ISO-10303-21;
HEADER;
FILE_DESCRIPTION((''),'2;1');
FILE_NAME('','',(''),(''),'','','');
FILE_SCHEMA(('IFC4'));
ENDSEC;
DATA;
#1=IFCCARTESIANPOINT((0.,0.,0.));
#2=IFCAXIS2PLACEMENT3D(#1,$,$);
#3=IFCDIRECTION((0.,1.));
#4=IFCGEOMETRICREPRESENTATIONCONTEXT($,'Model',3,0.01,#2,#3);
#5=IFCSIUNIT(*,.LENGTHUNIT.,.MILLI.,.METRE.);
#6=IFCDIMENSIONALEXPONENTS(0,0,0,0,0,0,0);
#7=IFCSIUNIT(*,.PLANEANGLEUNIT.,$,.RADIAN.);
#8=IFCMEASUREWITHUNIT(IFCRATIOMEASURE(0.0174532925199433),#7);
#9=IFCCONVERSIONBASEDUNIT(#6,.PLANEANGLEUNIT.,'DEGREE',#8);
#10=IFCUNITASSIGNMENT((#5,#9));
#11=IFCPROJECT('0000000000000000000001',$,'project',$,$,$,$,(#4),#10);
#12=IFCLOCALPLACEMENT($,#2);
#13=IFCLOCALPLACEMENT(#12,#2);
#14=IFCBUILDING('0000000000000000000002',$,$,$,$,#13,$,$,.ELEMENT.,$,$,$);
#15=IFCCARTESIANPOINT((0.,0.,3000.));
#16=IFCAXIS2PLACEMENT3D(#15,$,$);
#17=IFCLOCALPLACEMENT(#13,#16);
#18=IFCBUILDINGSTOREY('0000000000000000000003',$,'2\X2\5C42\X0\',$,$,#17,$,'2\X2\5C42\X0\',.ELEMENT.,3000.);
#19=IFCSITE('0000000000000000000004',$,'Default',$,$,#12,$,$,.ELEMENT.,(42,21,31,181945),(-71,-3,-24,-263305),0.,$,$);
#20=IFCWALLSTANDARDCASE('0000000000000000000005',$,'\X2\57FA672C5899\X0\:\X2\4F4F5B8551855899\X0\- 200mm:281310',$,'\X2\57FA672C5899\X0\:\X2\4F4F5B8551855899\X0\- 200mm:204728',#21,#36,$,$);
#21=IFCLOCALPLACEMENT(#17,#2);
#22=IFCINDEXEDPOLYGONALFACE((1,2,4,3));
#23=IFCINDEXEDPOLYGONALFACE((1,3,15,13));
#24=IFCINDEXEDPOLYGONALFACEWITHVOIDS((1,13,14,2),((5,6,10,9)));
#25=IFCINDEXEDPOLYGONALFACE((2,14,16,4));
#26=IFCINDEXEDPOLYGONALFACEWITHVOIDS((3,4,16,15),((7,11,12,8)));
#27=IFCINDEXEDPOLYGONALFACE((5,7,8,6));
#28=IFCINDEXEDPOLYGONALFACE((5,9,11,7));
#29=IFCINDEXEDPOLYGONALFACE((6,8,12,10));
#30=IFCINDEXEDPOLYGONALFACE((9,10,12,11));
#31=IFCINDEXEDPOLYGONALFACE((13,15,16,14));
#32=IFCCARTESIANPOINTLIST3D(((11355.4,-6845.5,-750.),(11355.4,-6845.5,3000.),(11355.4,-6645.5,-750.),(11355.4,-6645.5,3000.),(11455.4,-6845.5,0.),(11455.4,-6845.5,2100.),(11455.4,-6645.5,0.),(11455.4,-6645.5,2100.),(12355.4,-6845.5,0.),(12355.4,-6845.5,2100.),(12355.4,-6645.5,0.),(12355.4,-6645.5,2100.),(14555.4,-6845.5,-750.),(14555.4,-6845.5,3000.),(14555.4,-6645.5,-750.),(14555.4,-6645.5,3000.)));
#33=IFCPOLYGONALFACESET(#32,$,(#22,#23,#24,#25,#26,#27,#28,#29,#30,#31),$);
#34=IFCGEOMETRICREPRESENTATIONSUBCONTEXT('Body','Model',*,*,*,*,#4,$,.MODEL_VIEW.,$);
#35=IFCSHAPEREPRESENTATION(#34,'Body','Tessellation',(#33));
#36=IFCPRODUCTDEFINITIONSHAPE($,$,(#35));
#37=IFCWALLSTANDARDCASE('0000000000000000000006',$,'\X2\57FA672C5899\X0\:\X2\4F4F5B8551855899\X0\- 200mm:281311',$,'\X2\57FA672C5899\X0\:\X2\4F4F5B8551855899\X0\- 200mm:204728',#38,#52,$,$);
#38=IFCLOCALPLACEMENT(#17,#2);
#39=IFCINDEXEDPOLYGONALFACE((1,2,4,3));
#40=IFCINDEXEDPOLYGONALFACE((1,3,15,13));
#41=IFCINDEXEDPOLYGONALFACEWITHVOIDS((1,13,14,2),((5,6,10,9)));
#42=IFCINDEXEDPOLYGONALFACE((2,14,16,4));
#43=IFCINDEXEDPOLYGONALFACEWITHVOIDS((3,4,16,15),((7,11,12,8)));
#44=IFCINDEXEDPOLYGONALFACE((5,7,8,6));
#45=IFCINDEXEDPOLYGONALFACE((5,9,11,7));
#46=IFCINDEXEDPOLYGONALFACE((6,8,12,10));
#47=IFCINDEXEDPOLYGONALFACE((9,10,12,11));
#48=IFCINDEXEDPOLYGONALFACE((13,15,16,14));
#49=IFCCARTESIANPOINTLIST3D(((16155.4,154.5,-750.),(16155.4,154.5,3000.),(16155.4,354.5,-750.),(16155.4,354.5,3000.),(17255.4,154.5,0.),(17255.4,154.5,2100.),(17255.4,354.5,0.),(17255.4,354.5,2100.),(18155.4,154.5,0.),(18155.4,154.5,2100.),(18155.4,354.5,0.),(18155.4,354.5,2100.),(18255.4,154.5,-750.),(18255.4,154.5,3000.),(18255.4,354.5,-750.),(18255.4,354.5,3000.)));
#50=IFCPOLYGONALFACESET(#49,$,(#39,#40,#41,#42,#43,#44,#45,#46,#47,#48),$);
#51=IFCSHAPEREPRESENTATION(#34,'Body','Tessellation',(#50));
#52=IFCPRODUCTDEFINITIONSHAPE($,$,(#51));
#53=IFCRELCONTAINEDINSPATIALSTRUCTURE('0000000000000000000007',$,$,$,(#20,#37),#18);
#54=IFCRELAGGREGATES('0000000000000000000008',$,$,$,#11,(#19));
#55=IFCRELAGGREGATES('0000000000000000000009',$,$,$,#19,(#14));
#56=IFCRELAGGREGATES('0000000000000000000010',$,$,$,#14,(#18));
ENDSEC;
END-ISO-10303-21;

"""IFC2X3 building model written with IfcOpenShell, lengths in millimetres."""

from ifc_helpers import new_model, entity, si_unit, converted_unit, direction, frame, frame_2d, origin, place, context, subcontext, project, spatial, polyline, rectangle, extrude, clip, bounded_halfspace, element, save


model = new_model("IFC2X3")

# Units and contexts
model_context = context("Model", 3, precision=0.01, world=origin(), true_north=direction((0.0, 1.0)))
body_context = subcontext(model_context, "Body", "Model", "MODEL_VIEW")
ifc_project = project(units=[si_unit("LENGTHUNIT", "METRE", prefix="MILLI"), converted_unit("PLANEANGLEUNIT", "DEGREE", entity("IfcRatioMeasure", 0.0174532925199433), si_unit("PLANEANGLEUNIT", "RADIAN"), dimensions=[0, 0, 0, 0, 0, 0, 0])], contexts=[model_context])

# Site, building, storey
site_placement = place(None, origin())
site = spatial("IfcSite", under=ifc_project, at=site_placement, Name="Default", CompositionType="ELEMENT", RefLatitude=(42, 21, 31, 181945), RefLongitude=(-71, -3, -24, -263305), RefElevation=0.0)
building_placement = place(site_placement, origin())
building = spatial("IfcBuilding", under=site, at=building_placement, CompositionType="ELEMENT")
storey_placement = place(building_placement, frame((0.0, 0.0, 3000.0)))
storey = spatial("IfcBuildingStorey", under=building, at=storey_placement, Name="2层", LongName="2层", CompositionType="ELEMENT", Elevation=3000.0)

# Wall, openings
wall_1_placement = place(storey_placement, frame((11355.4, -6745.5, -750.0)))
wall_1 = element("IfcWallStandardCase", 1, at=wall_1_placement, inside=storey, Name="基本墙:住宅内墙- 200mm:281310", ObjectType="基本墙:住宅内墙- 200mm:204728", context=body_context, shape_type="Clipping", body=[
    clip(clip(extrude(rectangle(XDim=3200.0, YDim=200.0, at=frame_2d((1600.0, 0.0), x_axis=(-1.0, 0.0))), origin(), (0.0, 0.0, 1.0), 3750.0), bounded_halfspace(frame((0.0, -100.0, 0.0), z_axis=(1.0, 0.0, 0.0), x_axis=(0.0, 0.0, -1.0)), True, frame((0.0, -100.0, 0.0), z_axis=(1.0, 0.0, 0.0), x_axis=(0.0, 0.0, -1.0)), polyline([(0.0, 0.0), (0.0, 200.0), (-3750.0, 200.0), (-3750.0, 0.0), (0.0, 0.0)]))), bounded_halfspace(frame((3200.0, -100.0, 3750.0), z_axis=(1.0, 0.0, 0.0), x_axis=(0.0, 0.0, -1.0)), False, frame((3200.0, -100.0, 3750.0), z_axis=(1.0, 0.0, 0.0), x_axis=(0.0, 0.0, -1.0)), polyline([(0.0, 0.0), (3750.0, 0.0), (3750.0, 200.0), (0.0, 200.0), (0.0, 0.0)]))),
])
opening_1_placement = place(wall_1_placement, origin())
element("IfcOpeningElement", 2, at=opening_1_placement, cuts=wall_1, ObjectType="Opening", context=body_context, shape_type="SweptSolid", body=[
    extrude(rectangle(XDim=2100.0, YDim=900.0, at=frame_2d((0.0, 0.0), x_axis=(1.0, 0.0))), frame((550.0, -1424.0, 4800.0), z_axis=(0.0, 1.0, 0.0), x_axis=(0.0, 0.0, 1.0)), (0.0, 0.0, 1.0), 3048.0),
])
opening_2_placement = place(wall_1_placement, origin())
element("IfcOpeningElement", 3, at=opening_2_placement, cuts=wall_1, ObjectType="Opening", context=body_context, shape_type="SweptSolid", body=[
    extrude(rectangle(XDim=2100.0, YDim=900.0, at=frame_2d((0.0, 0.0), x_axis=(1.0, 0.0))), frame((550.0, -1424.0, 1800.0), z_axis=(0.0, 1.0, 0.0), x_axis=(0.0, 0.0, 1.0)), (0.0, 0.0, 1.0), 3048.0),
])

# Wall, opening
wall_2_placement = place(storey_placement, frame((18255.4, 254.5, -750.0), z_axis=(0.0, 0.0, 1.0), x_axis=(-1.0, 0.0, 0.0)))
wall_2 = element("IfcWallStandardCase", 4, at=wall_2_placement, inside=storey, Name="基本墙:住宅内墙- 200mm:281311", ObjectType="基本墙:住宅内墙- 200mm:204728", context=body_context, shape_type="SweptSolid", body=[
    extrude(rectangle(XDim=2100.0, YDim=200.0, at=frame_2d((1050.0, 0.0), x_axis=(-1.0, 0.0))), origin(), (0.0, 0.0, 1.0), 3750.0),
])
opening_3_placement = place(wall_2_placement, frame((1000.0, 100.0, 750.0)))
element("IfcOpeningElement", 5, at=opening_3_placement, cuts=wall_2, ObjectType="Opening", context=body_context, shape_type="SweptSolid", body=[
    extrude(rectangle(XDim=2100.0, YDim=900.0, at=frame_2d((1050.0, 450.0), x_axis=(1.0, 0.0))), frame((0.0, 0.0, 0.0), z_axis=(0.0, -1.0, 0.0), x_axis=(0.0, 0.0, 1.0)), (0.0, 0.0, 1.0), 200.0),
])

save(model, "model.ifc")
